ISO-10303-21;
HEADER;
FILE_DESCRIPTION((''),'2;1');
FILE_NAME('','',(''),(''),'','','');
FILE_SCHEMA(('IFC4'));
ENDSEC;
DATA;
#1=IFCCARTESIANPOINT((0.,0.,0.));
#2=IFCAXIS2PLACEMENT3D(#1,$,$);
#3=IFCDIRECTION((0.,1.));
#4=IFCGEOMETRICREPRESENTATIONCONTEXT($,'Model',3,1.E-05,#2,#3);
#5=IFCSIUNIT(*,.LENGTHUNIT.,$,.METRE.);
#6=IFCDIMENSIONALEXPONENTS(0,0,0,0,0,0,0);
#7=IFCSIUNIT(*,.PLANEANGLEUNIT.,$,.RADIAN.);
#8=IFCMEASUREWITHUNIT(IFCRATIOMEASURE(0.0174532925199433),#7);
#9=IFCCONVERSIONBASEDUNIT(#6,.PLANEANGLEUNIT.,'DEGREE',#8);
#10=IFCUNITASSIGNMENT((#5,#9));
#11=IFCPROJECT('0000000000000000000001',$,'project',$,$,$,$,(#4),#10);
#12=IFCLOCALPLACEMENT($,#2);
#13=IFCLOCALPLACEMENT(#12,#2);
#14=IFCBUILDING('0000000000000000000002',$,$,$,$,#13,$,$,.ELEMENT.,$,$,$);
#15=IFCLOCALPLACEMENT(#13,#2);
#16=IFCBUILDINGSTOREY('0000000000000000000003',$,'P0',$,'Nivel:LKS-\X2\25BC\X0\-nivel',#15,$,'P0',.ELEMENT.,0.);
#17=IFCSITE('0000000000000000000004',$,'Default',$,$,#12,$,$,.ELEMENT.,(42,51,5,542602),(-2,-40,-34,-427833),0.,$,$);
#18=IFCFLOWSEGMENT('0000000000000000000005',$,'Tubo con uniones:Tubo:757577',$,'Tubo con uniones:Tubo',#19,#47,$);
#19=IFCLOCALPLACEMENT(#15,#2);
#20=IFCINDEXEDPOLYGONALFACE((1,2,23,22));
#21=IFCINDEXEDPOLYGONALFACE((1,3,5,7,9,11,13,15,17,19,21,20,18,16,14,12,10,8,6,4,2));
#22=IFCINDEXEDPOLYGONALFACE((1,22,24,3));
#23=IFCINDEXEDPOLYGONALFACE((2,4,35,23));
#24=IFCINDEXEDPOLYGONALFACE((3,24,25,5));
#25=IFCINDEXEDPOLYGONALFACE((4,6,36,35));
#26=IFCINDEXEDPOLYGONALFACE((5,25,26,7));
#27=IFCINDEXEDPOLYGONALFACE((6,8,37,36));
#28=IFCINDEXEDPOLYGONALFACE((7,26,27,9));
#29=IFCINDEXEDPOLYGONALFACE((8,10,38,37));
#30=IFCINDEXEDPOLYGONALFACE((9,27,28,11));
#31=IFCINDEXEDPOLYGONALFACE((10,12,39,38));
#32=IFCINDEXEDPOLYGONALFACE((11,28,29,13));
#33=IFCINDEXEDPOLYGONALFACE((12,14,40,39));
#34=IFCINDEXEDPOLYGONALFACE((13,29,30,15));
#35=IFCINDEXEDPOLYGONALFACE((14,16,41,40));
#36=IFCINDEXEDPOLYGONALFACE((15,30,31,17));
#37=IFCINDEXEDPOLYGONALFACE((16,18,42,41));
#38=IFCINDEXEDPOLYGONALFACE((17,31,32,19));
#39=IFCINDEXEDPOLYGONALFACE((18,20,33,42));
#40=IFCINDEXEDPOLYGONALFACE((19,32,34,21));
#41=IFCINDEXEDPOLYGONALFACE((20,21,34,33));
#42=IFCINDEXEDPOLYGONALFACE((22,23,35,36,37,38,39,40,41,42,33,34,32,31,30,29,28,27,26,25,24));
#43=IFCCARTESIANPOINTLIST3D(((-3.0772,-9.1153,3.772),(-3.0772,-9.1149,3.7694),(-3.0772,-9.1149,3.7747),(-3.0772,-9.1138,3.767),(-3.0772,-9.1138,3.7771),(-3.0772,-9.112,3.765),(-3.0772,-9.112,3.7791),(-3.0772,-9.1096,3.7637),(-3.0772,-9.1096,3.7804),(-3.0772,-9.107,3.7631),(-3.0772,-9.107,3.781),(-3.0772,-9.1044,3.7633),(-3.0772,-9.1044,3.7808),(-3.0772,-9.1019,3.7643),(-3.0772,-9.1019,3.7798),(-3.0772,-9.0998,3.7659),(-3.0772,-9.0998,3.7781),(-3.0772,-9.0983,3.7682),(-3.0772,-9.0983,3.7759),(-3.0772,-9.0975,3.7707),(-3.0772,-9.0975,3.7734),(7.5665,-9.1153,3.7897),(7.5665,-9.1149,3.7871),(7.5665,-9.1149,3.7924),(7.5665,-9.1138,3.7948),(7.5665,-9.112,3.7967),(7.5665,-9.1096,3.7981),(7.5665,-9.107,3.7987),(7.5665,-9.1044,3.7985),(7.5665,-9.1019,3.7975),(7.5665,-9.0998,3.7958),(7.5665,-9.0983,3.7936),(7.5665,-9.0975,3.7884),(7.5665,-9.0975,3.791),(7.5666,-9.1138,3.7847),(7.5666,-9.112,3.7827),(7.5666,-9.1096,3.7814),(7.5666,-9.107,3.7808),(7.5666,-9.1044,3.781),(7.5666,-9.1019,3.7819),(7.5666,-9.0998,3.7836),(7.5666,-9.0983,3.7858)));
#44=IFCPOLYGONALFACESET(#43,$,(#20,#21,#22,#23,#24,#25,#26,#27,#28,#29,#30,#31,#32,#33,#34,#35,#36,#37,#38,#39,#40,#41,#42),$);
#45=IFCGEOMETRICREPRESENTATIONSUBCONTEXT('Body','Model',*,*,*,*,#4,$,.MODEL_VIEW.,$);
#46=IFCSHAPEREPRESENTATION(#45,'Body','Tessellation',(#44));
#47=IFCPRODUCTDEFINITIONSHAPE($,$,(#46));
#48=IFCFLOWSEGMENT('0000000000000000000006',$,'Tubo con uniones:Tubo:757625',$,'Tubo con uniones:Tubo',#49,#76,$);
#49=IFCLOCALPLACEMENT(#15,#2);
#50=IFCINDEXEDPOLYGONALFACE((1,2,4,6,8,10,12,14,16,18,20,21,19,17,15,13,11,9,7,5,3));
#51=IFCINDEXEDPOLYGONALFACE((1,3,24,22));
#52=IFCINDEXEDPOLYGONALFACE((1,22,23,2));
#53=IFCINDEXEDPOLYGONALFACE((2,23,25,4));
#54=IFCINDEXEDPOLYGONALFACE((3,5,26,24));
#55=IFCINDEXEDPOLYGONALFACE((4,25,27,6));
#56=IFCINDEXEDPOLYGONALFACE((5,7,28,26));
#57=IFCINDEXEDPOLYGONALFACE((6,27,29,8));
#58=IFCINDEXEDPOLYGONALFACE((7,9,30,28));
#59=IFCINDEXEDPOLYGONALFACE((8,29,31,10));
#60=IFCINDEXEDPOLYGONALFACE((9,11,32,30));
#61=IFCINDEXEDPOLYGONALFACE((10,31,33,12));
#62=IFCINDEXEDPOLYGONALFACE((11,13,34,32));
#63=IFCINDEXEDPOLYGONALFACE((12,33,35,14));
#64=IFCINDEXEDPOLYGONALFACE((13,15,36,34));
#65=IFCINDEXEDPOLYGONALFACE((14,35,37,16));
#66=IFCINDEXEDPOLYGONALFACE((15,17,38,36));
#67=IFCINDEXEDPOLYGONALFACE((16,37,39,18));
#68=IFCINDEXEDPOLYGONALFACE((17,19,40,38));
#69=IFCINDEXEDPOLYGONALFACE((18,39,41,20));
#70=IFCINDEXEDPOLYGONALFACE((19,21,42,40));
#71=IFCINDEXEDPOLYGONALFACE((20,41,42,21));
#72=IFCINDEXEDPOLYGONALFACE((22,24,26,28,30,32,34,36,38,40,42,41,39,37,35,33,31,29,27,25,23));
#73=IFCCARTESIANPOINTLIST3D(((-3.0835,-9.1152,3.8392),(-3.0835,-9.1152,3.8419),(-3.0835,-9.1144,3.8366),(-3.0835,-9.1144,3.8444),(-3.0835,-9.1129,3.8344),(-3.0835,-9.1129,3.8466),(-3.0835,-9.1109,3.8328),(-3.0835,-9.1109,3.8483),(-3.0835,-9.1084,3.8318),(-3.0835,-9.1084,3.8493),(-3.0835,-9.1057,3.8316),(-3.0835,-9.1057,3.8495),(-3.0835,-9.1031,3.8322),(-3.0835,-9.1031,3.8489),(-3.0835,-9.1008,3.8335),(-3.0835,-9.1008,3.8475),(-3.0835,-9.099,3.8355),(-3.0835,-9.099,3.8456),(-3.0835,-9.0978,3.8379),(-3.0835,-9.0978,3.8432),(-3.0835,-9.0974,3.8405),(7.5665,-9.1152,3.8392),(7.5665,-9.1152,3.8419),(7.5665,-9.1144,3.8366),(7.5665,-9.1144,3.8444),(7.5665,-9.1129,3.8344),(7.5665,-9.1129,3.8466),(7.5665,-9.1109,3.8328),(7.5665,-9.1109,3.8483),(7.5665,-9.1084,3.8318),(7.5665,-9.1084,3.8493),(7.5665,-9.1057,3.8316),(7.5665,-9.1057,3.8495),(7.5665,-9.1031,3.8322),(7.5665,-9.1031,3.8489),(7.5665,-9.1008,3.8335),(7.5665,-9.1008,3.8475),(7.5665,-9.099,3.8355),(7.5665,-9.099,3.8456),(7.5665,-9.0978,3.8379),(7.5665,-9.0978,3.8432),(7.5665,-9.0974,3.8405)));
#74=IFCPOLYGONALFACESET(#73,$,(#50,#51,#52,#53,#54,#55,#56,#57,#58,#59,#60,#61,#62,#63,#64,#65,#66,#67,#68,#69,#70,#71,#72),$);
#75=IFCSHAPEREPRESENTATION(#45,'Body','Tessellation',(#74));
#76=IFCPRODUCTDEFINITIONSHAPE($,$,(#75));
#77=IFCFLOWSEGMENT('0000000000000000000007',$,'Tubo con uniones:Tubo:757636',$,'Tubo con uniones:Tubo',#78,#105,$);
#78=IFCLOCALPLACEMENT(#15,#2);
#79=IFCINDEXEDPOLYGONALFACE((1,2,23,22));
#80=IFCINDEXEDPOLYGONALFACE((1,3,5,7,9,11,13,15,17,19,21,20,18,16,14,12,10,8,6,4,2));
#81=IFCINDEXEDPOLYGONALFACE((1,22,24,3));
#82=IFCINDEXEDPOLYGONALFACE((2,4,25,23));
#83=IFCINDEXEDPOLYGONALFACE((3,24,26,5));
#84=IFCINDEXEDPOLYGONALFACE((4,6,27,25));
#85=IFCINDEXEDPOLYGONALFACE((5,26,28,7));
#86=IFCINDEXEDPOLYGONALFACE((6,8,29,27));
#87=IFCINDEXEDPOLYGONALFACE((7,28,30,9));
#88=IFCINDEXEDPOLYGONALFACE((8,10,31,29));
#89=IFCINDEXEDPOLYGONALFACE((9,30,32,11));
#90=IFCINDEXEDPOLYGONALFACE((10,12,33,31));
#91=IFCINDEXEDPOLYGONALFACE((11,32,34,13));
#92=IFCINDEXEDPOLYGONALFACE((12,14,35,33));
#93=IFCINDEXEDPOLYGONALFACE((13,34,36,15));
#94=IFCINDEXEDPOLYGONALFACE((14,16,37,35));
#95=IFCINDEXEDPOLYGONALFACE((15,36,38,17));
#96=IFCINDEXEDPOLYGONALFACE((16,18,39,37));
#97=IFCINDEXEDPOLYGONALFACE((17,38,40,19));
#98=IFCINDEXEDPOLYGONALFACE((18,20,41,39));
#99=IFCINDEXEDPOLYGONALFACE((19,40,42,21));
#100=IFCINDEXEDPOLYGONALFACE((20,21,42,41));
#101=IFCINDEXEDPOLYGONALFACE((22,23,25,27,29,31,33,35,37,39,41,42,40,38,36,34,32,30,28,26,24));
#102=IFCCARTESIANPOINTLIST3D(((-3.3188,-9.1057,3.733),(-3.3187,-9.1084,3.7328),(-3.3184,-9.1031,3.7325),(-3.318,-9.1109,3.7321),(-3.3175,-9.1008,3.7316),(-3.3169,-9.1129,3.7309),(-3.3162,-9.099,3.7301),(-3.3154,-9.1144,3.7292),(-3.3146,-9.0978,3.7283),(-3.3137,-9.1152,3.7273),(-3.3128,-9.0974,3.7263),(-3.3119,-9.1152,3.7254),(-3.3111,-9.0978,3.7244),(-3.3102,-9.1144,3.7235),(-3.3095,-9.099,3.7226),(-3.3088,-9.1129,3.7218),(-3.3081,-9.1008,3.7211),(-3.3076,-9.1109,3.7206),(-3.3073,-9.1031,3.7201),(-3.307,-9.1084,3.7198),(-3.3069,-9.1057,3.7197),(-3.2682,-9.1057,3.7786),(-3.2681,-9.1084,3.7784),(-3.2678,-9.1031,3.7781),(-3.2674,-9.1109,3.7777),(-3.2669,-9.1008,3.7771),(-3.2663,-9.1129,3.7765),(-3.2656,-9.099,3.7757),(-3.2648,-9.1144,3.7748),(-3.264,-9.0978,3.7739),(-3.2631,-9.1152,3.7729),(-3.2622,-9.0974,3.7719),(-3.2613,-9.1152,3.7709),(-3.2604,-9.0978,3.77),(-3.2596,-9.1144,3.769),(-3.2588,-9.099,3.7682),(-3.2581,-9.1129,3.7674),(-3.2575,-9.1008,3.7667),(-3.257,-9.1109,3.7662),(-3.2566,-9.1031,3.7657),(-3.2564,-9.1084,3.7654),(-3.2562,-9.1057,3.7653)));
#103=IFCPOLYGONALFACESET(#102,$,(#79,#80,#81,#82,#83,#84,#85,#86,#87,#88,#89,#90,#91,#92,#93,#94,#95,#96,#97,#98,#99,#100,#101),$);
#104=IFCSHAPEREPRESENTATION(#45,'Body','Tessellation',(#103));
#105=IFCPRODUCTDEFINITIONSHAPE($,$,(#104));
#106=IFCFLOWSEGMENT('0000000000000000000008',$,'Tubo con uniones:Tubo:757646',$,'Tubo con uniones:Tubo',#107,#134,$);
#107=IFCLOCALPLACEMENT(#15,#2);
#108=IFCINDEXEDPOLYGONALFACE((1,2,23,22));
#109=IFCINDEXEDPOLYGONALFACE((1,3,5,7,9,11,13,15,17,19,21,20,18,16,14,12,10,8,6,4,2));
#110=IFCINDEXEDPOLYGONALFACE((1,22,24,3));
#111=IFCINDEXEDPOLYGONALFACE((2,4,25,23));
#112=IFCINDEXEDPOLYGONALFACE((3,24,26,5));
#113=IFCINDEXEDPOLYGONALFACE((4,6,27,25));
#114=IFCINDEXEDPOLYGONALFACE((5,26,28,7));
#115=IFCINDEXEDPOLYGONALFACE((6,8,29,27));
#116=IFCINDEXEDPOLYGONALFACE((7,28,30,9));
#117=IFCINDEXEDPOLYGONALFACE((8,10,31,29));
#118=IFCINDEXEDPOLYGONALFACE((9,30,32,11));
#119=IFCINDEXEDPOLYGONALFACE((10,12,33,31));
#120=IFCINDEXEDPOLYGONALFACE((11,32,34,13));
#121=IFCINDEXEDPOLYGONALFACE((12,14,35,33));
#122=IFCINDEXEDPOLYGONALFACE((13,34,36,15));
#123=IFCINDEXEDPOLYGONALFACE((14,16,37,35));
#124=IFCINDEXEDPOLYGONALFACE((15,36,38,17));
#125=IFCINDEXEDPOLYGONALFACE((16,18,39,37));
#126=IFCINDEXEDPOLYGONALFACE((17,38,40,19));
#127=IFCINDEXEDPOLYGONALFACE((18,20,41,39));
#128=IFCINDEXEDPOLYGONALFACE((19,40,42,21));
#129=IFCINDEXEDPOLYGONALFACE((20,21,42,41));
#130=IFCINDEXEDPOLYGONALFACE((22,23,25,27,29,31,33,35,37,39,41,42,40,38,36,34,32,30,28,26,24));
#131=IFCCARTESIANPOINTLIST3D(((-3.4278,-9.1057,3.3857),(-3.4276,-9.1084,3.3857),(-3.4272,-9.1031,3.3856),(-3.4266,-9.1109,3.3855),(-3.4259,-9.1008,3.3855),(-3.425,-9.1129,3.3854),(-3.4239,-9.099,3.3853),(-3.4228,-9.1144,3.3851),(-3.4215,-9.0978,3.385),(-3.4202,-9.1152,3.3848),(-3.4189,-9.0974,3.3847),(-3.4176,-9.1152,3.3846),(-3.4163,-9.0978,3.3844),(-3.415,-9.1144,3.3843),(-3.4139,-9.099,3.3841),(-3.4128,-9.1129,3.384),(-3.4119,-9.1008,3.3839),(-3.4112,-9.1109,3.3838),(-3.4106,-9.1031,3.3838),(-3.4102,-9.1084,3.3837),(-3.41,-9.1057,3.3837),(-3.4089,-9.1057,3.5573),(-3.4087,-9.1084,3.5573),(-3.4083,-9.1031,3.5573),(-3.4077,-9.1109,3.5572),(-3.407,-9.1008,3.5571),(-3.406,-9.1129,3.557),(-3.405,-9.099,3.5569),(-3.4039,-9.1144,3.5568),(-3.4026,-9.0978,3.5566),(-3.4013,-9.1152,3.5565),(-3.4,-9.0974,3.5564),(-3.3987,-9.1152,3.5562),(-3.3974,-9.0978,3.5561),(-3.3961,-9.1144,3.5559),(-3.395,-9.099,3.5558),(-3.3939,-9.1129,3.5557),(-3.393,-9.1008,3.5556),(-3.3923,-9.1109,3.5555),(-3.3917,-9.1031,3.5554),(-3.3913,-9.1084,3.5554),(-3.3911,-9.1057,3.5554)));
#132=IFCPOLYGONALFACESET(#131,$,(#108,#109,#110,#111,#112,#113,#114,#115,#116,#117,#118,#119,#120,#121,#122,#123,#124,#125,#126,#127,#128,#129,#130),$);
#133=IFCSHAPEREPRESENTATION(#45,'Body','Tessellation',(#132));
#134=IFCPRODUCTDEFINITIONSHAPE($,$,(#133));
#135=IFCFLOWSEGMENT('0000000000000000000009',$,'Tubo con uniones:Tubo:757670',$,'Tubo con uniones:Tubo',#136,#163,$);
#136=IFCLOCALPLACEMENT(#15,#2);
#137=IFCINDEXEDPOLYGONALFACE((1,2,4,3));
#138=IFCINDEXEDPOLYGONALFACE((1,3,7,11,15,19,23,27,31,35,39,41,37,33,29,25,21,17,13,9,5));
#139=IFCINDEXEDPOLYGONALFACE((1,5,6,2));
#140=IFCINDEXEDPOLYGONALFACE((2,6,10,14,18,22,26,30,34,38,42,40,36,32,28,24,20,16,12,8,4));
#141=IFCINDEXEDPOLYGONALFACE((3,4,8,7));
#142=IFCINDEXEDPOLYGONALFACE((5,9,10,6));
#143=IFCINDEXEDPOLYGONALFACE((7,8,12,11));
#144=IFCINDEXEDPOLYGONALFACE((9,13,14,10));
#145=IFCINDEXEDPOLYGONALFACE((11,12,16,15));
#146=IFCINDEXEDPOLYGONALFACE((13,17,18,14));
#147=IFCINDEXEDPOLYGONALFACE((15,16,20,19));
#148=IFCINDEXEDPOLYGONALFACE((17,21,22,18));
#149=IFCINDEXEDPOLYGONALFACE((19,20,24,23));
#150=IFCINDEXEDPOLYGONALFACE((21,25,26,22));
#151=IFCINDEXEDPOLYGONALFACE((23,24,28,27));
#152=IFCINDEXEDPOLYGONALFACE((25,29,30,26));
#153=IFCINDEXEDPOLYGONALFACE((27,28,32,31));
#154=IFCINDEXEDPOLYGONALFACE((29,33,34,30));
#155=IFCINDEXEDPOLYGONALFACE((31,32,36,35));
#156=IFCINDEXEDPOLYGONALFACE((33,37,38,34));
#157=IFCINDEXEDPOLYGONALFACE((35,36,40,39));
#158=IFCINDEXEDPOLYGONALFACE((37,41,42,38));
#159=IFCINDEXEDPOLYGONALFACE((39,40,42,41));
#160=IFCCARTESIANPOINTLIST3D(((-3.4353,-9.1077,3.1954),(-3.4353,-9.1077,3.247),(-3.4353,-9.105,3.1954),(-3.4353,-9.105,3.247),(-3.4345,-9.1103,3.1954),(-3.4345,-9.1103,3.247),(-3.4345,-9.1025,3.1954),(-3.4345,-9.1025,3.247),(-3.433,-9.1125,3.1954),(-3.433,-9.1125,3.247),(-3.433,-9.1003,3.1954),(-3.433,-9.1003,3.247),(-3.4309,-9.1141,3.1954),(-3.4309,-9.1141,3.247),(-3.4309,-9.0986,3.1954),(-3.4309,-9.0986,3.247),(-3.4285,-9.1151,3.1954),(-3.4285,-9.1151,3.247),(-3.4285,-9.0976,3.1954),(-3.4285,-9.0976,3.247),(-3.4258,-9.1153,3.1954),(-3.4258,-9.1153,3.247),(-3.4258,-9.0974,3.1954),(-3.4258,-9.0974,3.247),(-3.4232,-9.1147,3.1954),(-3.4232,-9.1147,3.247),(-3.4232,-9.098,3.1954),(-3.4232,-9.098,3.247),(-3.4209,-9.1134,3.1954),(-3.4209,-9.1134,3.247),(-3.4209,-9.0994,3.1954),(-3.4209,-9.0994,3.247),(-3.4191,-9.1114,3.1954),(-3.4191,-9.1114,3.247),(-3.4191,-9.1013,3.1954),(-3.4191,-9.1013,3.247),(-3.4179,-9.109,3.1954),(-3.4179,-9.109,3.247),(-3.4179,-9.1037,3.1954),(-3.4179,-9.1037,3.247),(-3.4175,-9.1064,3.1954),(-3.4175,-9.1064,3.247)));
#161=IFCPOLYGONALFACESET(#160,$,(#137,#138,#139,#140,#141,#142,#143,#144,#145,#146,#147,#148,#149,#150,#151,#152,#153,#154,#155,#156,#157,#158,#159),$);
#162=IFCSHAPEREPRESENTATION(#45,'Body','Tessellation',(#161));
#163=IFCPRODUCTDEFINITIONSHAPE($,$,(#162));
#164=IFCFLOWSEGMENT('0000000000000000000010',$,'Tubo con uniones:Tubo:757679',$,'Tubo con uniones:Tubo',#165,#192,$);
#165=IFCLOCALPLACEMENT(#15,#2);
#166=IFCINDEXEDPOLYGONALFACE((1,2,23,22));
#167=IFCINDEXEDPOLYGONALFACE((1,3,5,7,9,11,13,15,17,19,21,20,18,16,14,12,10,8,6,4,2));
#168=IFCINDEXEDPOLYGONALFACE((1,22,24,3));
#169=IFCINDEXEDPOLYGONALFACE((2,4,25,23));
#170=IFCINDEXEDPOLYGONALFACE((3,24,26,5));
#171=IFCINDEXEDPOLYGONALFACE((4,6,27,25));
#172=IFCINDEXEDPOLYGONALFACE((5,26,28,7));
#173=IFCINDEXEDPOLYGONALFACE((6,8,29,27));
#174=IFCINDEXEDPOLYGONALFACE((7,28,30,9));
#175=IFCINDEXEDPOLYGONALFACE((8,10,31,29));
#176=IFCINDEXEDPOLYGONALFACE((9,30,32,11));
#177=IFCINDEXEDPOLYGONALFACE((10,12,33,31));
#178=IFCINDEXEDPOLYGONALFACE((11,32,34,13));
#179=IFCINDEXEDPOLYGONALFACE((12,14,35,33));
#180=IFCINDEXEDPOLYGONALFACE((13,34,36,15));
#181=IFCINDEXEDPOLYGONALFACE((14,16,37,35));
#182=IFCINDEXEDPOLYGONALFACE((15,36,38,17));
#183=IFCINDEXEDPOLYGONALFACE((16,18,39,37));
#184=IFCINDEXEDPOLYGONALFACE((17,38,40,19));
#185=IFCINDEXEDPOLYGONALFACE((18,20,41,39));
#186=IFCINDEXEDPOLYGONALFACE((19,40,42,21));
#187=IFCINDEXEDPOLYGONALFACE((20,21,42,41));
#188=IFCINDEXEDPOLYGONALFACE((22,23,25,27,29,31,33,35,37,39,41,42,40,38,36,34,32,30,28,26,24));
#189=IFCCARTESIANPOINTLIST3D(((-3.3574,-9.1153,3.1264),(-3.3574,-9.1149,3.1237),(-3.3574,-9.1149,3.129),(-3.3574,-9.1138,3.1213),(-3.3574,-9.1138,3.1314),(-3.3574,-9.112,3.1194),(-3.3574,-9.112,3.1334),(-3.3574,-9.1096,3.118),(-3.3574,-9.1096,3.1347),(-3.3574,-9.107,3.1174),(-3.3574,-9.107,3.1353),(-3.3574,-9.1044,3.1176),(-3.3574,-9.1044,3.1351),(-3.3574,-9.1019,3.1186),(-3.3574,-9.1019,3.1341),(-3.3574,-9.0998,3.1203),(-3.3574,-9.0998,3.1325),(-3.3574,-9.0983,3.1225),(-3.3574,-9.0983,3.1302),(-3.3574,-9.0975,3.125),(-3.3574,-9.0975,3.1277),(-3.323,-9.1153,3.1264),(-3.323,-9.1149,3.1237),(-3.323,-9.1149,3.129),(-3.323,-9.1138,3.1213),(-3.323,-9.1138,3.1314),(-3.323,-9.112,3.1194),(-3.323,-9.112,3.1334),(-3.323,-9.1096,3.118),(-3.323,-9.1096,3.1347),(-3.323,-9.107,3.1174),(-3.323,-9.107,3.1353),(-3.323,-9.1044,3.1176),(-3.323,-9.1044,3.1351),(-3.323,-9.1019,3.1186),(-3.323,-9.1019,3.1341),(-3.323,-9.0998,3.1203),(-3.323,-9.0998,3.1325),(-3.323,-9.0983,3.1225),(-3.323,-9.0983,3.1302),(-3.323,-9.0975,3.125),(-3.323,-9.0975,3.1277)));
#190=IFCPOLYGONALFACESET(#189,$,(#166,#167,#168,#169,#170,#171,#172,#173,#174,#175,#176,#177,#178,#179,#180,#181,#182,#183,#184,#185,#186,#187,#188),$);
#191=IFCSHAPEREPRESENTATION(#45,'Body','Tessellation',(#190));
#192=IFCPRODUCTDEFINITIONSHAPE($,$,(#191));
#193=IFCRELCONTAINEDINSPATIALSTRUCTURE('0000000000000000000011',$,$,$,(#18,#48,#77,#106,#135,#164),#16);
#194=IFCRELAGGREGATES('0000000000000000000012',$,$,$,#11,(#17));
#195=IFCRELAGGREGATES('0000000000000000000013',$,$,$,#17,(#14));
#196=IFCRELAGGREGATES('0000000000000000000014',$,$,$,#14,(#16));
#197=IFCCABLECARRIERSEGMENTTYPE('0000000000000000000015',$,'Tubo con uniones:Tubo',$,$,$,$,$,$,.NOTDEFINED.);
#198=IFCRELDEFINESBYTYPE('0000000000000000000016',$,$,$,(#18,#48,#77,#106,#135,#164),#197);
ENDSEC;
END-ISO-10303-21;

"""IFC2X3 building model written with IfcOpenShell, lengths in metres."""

from ifc_helpers import new_model, entity, si_unit, converted_unit, direction, frame, frame_2d, origin, origin_2d_with_axis, place, context, subcontext, project, spatial, circle, extrude, type_object, element, save


model = new_model("IFC2X3")

# Units and contexts
model_context = context("Model", 3, precision=1e-05, world=origin(), true_north=direction((0.0, 1.0)))
body_context = subcontext(model_context, "Body", "Model", "MODEL_VIEW")
ifc_project = project(units=[si_unit("LENGTHUNIT", "METRE"), converted_unit("PLANEANGLEUNIT", "DEGREE", entity("IfcRatioMeasure", 0.0174532925199433), si_unit("PLANEANGLEUNIT", "RADIAN"), dimensions=[0, 0, 0, 0, 0, 0, 0])], contexts=[model_context])

# Site, building, storey
site_placement = place(None, origin())
site = spatial("IfcSite", under=ifc_project, at=site_placement, Name="Default", CompositionType="ELEMENT", RefLatitude=(42, 51, 5, 542602), RefLongitude=(-2, -40, -34, -427833), RefElevation=0.0)
building_placement = place(site_placement, origin())
building = spatial("IfcBuilding", under=site, at=building_placement, CompositionType="ELEMENT")
storey_placement = place(building_placement, origin())
storey = spatial("IfcBuildingStorey", under=building, at=storey_placement, Name="P0", ObjectType="Nivel:LKS-▼-nivel", LongName="P0", CompositionType="ELEMENT", Elevation=0.0)

# Flow segments
cable_carrier_segment_type = type_object("IfcCableCarrierSegmentType", Name="Tubo con uniones:Tubo", PredefinedType="NOTDEFINED")
flow_segment_1_placement = place(storey_placement, origin())
element("IfcFlowSegment", 1, at=flow_segment_1_placement, inside=storey, type_object=cable_carrier_segment_type, Name="Tubo con uniones:Tubo:757577", ObjectType="Tubo con uniones:Tubo", context=body_context, shape_type="SweptSolid", body=[
    extrude(circle(Radius=0.009, at=origin_2d_with_axis()), frame((-3.0772, -9.1064, 3.772), z_axis=(0.999999, 0.0, 0.00166), x_axis=(0.0, -1.0, 0.0)), (0.0, 0.0, 1.0), 10.6437),
])
flow_segment_2_placement = place(storey_placement, origin())
element("IfcFlowSegment", 2, at=flow_segment_2_placement, inside=storey, type_object=cable_carrier_segment_type, Name="Tubo con uniones:Tubo:757625", ObjectType="Tubo con uniones:Tubo", context=body_context, shape_type="SweptSolid", body=[
    extrude(circle(Radius=0.009, at=frame_2d((0.0, 0.0), x_axis=(1.0, 0.0))), frame((-3.0835, -9.1064, 3.8405), z_axis=(1.0, 0.0, 0.0), x_axis=(0.0, 1.0, 0.0)), (0.0, 0.0, 1.0), 10.6501),
])
flow_segment_3_placement = place(storey_placement, origin())
element("IfcFlowSegment", 3, at=flow_segment_3_placement, inside=storey, type_object=cable_carrier_segment_type, Name="Tubo con uniones:Tubo:757636", ObjectType="Tubo con uniones:Tubo", context=body_context, shape_type="SweptSolid", body=[
    extrude(circle(Radius=0.009, at=origin_2d_with_axis()), frame((-3.3128, -9.1064, 3.7263), z_axis=(0.743145, 0.0, 0.669131), x_axis=(0.0, 1.0, 0.0)), (0.0, 0.0, 1.0), 0.0681),
])
flow_segment_4_placement = place(storey_placement, origin())
element("IfcFlowSegment", 4, at=flow_segment_4_placement, inside=storey, type_object=cable_carrier_segment_type, Name="Tubo con uniones:Tubo:757646", ObjectType="Tubo con uniones:Tubo", context=body_context, shape_type="SweptSolid", body=[
    extrude(circle(Radius=0.009, at=frame_2d((0.0, 0.0), x_axis=(1.0, 0.0))), frame((-3.4189, -9.1064, 3.3847), z_axis=(0.109491, 0.0, 0.993988), x_axis=(0.0, 1.0, 0.0)), (0.0, 0.0, 1.0), 0.1727),
])
flow_segment_5_placement = place(storey_placement, origin())
element("IfcFlowSegment", 5, at=flow_segment_5_placement, inside=storey, type_object=cable_carrier_segment_type, Name="Tubo con uniones:Tubo:757670", ObjectType="Tubo con uniones:Tubo", context=body_context, shape_type="SweptSolid", body=[
    extrude(circle(Radius=0.009, at=frame_2d((0.0, 0.0), x_axis=(1.0, 0.0))), frame((-3.4265, -9.1064, 3.1954)), (0.0, 0.0, 1.0), 0.0516),
])
flow_segment_6_placement = place(storey_placement, origin())
element("IfcFlowSegment", 6, at=flow_segment_6_placement, inside=storey, type_object=cable_carrier_segment_type, Name="Tubo con uniones:Tubo:757679", ObjectType="Tubo con uniones:Tubo", context=body_context, shape_type="SweptSolid", body=[
    extrude(circle(Radius=0.009, at=origin_2d_with_axis()), frame((-3.3574, -9.1064, 3.1264), z_axis=(1.0, 0.0, 0.0), x_axis=(0.0, -1.0, 0.0)), (0.0, 0.0, 1.0), 0.0344),
])

save(model, "model.ifc")
